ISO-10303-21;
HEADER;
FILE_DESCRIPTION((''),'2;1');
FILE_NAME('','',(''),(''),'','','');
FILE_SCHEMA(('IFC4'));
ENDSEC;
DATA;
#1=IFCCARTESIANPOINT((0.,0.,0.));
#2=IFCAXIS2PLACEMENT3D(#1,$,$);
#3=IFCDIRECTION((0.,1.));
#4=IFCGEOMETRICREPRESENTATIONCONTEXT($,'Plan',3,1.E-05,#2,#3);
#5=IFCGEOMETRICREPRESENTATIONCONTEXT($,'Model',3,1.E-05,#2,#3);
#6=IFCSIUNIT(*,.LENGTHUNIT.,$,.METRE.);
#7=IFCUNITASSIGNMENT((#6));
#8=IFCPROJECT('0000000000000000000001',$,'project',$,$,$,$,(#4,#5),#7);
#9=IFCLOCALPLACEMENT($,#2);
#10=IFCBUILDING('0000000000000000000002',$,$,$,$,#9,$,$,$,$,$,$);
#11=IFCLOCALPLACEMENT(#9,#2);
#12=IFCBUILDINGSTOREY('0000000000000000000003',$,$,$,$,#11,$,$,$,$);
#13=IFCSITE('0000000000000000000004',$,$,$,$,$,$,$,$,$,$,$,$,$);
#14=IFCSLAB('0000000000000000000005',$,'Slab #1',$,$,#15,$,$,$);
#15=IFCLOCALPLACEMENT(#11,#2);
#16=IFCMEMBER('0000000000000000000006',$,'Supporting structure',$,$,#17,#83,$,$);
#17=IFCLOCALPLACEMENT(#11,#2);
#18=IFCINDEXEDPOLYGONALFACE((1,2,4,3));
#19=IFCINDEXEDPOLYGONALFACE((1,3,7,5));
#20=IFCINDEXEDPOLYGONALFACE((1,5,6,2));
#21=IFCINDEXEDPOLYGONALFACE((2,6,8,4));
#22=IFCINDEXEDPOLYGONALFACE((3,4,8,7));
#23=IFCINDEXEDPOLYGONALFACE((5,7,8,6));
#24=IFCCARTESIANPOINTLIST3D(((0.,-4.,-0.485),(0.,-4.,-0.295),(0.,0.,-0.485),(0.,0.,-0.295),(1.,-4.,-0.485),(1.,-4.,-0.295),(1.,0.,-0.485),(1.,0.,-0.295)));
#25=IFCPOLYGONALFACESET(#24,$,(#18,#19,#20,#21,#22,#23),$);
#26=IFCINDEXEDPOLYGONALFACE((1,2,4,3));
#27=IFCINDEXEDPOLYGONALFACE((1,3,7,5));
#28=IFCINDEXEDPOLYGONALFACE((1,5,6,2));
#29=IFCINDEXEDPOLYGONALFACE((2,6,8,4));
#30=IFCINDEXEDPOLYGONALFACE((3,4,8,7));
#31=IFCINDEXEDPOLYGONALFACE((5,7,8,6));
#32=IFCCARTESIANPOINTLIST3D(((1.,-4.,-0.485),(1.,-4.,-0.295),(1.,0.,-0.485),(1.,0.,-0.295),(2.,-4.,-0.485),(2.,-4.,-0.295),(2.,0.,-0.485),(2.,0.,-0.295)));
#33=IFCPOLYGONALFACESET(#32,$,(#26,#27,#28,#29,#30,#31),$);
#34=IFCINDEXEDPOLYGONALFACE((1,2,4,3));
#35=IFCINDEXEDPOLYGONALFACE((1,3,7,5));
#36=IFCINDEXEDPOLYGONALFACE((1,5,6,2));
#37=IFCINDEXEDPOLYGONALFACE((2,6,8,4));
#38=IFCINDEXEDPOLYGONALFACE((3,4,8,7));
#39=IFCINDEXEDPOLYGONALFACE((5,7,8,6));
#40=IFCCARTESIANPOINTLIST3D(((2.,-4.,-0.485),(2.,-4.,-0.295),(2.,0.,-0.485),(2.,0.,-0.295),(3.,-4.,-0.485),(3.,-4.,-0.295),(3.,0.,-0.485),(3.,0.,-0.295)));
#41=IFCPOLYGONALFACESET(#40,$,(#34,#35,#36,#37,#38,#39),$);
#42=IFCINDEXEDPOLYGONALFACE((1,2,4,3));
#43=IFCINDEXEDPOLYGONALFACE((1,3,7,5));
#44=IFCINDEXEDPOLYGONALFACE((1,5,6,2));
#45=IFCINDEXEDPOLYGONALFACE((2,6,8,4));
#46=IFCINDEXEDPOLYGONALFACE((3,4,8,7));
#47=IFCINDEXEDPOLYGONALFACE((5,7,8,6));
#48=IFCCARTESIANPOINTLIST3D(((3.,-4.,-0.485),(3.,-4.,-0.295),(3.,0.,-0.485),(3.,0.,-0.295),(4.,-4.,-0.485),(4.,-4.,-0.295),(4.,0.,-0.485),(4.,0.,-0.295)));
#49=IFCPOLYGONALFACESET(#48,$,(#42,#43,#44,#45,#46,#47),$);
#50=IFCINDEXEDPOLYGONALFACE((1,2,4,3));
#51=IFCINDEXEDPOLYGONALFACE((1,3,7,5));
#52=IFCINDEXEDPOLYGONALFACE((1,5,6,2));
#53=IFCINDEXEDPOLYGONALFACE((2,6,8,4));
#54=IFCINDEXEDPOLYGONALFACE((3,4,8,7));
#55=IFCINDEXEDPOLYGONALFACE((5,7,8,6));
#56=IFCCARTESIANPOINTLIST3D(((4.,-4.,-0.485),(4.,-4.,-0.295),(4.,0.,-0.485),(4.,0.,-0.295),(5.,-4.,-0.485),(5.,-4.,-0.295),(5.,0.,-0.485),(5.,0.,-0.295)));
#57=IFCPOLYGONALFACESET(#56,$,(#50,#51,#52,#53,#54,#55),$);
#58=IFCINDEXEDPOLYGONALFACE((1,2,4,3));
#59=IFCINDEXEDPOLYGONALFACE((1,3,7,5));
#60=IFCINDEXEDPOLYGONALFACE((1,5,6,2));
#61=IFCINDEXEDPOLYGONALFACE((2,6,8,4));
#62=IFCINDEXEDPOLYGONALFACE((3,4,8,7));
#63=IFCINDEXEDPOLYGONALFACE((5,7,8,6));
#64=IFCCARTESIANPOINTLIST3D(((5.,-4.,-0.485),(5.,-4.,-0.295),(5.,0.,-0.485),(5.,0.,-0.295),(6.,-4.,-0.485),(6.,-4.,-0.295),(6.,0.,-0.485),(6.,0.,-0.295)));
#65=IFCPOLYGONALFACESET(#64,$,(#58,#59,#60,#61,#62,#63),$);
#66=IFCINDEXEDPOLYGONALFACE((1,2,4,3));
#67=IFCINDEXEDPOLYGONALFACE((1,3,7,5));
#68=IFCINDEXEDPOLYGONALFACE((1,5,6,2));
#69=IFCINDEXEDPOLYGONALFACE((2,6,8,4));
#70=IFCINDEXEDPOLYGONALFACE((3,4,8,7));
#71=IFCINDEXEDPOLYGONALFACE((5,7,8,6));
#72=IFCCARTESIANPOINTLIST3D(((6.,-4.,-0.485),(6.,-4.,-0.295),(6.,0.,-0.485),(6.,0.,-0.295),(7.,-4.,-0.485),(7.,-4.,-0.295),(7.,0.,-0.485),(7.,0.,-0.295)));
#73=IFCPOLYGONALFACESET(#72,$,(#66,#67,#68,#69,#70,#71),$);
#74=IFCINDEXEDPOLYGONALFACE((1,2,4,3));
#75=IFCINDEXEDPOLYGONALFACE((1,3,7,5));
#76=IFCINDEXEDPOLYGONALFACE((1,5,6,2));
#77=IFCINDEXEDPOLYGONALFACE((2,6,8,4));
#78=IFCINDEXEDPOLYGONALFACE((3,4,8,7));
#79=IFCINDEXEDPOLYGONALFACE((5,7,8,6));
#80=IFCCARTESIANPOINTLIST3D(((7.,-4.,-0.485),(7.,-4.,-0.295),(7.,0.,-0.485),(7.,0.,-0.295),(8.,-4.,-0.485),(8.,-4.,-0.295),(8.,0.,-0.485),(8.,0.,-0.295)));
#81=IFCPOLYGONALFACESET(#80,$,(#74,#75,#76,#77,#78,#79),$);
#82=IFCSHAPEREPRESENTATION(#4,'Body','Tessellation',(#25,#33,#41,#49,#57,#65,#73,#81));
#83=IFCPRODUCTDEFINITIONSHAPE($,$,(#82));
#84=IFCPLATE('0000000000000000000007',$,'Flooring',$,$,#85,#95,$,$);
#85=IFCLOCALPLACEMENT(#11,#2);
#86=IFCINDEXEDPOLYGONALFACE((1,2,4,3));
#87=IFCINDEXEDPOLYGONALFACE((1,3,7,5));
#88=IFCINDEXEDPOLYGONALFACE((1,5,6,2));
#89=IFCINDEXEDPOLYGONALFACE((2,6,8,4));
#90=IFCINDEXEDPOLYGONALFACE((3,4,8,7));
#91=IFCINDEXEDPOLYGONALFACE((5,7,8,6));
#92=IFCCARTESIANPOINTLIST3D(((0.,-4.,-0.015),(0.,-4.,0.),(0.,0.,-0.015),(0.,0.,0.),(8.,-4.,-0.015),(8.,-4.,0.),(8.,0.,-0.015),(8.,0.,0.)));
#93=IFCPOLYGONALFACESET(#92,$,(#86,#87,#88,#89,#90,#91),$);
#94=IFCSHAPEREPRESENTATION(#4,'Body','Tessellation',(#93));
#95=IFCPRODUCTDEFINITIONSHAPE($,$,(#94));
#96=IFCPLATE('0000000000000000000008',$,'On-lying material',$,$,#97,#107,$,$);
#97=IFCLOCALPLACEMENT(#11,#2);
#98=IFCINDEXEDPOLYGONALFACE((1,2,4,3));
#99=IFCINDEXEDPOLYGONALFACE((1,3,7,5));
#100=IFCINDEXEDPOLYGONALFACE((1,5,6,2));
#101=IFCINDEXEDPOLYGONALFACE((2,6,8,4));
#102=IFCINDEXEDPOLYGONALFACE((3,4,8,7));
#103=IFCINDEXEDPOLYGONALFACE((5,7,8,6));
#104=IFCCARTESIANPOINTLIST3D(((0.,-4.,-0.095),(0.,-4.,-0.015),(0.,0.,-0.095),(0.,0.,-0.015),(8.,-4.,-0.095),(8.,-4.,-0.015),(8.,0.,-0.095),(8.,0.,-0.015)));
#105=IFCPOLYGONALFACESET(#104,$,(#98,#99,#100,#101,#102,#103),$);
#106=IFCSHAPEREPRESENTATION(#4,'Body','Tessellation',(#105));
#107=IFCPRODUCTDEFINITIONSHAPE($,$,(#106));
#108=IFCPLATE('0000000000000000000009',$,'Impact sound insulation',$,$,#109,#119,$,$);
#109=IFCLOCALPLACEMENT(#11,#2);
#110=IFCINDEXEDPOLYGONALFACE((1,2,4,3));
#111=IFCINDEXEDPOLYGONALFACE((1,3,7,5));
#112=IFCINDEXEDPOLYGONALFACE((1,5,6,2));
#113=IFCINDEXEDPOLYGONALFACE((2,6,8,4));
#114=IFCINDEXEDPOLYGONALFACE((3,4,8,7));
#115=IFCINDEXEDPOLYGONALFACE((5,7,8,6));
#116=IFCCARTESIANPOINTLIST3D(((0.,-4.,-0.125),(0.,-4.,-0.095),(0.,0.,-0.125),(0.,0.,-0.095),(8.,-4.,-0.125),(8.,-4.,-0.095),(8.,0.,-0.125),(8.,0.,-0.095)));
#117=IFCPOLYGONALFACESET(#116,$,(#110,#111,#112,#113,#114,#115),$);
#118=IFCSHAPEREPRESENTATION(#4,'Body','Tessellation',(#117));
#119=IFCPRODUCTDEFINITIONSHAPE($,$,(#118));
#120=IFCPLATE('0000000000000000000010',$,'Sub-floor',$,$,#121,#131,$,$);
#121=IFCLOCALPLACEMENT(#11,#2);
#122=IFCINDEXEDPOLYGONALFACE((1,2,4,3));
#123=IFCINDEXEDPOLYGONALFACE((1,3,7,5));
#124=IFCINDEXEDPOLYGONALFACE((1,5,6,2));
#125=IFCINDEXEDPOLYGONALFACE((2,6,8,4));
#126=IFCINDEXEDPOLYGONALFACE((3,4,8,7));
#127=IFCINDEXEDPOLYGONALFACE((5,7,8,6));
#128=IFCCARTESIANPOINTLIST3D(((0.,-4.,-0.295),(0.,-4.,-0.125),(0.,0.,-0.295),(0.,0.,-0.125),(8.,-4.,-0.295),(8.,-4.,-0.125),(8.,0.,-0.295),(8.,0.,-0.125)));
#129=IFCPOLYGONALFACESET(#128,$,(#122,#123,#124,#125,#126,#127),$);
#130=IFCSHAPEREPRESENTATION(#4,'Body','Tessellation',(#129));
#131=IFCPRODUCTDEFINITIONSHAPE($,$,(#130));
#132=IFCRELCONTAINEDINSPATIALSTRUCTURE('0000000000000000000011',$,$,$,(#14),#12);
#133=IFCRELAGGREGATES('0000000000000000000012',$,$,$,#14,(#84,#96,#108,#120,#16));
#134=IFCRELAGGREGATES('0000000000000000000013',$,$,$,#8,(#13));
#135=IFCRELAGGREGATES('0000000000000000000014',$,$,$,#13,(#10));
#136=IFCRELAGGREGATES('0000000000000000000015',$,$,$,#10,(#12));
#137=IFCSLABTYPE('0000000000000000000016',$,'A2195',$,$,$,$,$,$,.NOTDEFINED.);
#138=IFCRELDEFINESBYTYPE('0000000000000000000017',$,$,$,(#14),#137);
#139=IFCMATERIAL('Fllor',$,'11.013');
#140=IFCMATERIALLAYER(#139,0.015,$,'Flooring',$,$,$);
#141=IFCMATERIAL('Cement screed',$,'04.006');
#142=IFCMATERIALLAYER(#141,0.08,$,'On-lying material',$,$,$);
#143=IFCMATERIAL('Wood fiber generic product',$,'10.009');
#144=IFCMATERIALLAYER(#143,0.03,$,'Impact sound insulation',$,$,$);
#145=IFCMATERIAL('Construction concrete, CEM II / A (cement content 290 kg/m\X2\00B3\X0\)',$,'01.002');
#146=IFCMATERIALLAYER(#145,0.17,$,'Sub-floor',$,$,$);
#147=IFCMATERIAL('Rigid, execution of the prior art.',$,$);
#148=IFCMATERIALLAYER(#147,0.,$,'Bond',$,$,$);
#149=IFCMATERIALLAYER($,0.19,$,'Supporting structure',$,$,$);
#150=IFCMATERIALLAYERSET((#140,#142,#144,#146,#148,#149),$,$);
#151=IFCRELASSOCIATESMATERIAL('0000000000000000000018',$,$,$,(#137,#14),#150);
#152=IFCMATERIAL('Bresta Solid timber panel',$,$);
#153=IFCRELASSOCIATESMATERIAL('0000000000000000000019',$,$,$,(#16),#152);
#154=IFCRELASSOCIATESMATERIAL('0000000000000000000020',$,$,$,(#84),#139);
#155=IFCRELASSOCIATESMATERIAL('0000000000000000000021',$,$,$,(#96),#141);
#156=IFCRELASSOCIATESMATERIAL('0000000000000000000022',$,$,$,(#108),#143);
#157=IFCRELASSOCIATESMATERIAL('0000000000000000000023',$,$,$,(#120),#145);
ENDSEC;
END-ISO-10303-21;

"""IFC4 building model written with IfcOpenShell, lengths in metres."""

from ifc_helpers import new_model, si_unit, direction, frame, frame_2d, origin, origin_with_axes, place, context, project, spatial, rectangle, extrude, material, layer, layer_set, type_object, element, aggregate, save


model = new_model("IFC4")

# Units and contexts
plan_context = context("Plan", 3, precision=1e-05, world=origin(), true_north=direction((0.0, 1.0)))
model_context = context("Model", 3, precision=1e-05, world=origin(), true_north=direction((0.0, 1.0)))
ifc_project = project(units=[si_unit("LENGTHUNIT", "METRE")], contexts=[plan_context, model_context])

# Site, building, storey
site = spatial("IfcSite", under=ifc_project)
building_placement = place(None, origin())
building = spatial("IfcBuilding", under=site, at=building_placement)
storey_placement = place(building_placement, origin())
storey = spatial("IfcBuildingStorey", under=building, at=storey_placement)

# Slab, member, plates
ifc_material_1 = material(Name="Fllor", Category="11.013")
ifc_layer_1 = layer(ifc_material_1, 0.015, Name="Flooring")
ifc_material_2 = material(Name="Cement screed", Category="04.006")
ifc_layer_2 = layer(ifc_material_2, 0.08, Name="On-lying material")
ifc_material_3 = material(Name="Wood fiber generic product", Category="10.009")
ifc_layer_3 = layer(ifc_material_3, 0.03, Name="Impact sound insulation")
ifc_material_4 = material(Name="Construction concrete, CEM II / A (cement content 290 kg/m³)", Category="01.002")
ifc_layer_4 = layer(ifc_material_4, 0.17, Name="Sub-floor")
ifc_material_5 = material(Name="Rigid, execution of the prior art.")
ifc_layer_5 = layer(ifc_material_5, 0.0, Name="Bond")
ifc_layer_6 = layer(None, 0.19, Name="Supporting structure")
ifc_layer_set = layer_set([ifc_layer_1, ifc_layer_2, ifc_layer_3, ifc_layer_4, ifc_layer_5, ifc_layer_6])
slab_type = type_object("IfcSlabType", Name="A2195", PredefinedType="NOTDEFINED", material=ifc_layer_set)
slab_placement = place(None, frame((0.0, 0.0, 0.0), z_axis=(0.0, 0.0, -1.0), x_axis=(1.0, 0.0, 0.0)))
slab = element("IfcSlab", 1, at=slab_placement, inside=storey, type_object=slab_type, material=ifc_layer_set, Name="Slab #1")
ifc_material_6 = material(Name="Bresta Solid timber panel")
member_placement = place(slab_placement, origin())
member = element("IfcMember", 2, at=member_placement, material=ifc_material_6, Name="Supporting structure", context=plan_context, shape_type="SweptSolid", body=[
    extrude(rectangle(XDim=1.0, YDim=0.19, at=frame_2d((0.5, 0.095), x_axis=(1.0, 0.0))), frame((0.0, 4.0, 0.295), z_axis=(0.0, -1.0, 0.0), x_axis=(1.0, 0.0, 0.0)), (0.0, 0.0, 1.0), 4.0),
    extrude(rectangle(XDim=1.0, YDim=0.19, at=frame_2d((0.5, 0.095), x_axis=(1.0, 0.0))), frame((1.0, 4.0, 0.295), z_axis=(0.0, -1.0, 0.0), x_axis=(1.0, 0.0, 0.0)), (0.0, 0.0, 1.0), 4.0),
    extrude(rectangle(XDim=1.0, YDim=0.19, at=frame_2d((0.5, 0.095), x_axis=(1.0, 0.0))), frame((2.0, 4.0, 0.295), z_axis=(0.0, -1.0, 0.0), x_axis=(1.0, 0.0, 0.0)), (0.0, 0.0, 1.0), 4.0),
    extrude(rectangle(XDim=1.0, YDim=0.19, at=frame_2d((0.5, 0.095), x_axis=(1.0, 0.0))), frame((3.0, 4.0, 0.295), z_axis=(0.0, -1.0, 0.0), x_axis=(1.0, 0.0, 0.0)), (0.0, 0.0, 1.0), 4.0),
    extrude(rectangle(XDim=1.0, YDim=0.19, at=frame_2d((0.5, 0.095), x_axis=(1.0, 0.0))), frame((4.0, 4.0, 0.295), z_axis=(0.0, -1.0, 0.0), x_axis=(1.0, 0.0, 0.0)), (0.0, 0.0, 1.0), 4.0),
    extrude(rectangle(XDim=1.0, YDim=0.19, at=frame_2d((0.5, 0.095), x_axis=(1.0, 0.0))), frame((5.0, 4.0, 0.295), z_axis=(0.0, -1.0, 0.0), x_axis=(1.0, 0.0, 0.0)), (0.0, 0.0, 1.0), 4.0),
    extrude(rectangle(XDim=1.0, YDim=0.19, at=frame_2d((0.5, 0.095), x_axis=(1.0, 0.0))), frame((6.0, 4.0, 0.295), z_axis=(0.0, -1.0, 0.0), x_axis=(1.0, 0.0, 0.0)), (0.0, 0.0, 1.0), 4.0),
    extrude(rectangle(XDim=1.0, YDim=0.19, at=frame_2d((0.5, 0.095), x_axis=(1.0, 0.0))), frame((7.0, 4.0, 0.295), z_axis=(0.0, -1.0, 0.0), x_axis=(1.0, 0.0, 0.0)), (0.0, 0.0, 1.0), 4.0),
])
plate_1_placement = place(slab_placement, origin())
plate_1 = element("IfcPlate", 3, at=plate_1_placement, material=ifc_material_1, Name="Flooring", context=plan_context, shape_type="SweptSolid", body=[
    extrude(rectangle(XDim=8.0, YDim=4.0, at=frame_2d((4.0, 2.0), x_axis=(1.0, 0.0))), origin_with_axes(), (0.0, 0.0, 1.0), 0.015),
])
plate_2_placement = place(slab_placement, origin())
plate_2 = element("IfcPlate", 4, at=plate_2_placement, material=ifc_material_2, Name="On-lying material", context=plan_context, shape_type="SweptSolid", body=[
    extrude(rectangle(XDim=8.0, YDim=4.0, at=frame_2d((4.0, 2.0), x_axis=(1.0, 0.0))), frame((0.0, 0.0, 0.015), z_axis=(0.0, 0.0, 1.0), x_axis=(1.0, 0.0, 0.0)), (0.0, 0.0, 1.0), 0.08),
])
plate_3_placement = place(slab_placement, origin())
plate_3 = element("IfcPlate", 5, at=plate_3_placement, material=ifc_material_3, Name="Impact sound insulation", context=plan_context, shape_type="SweptSolid", body=[
    extrude(rectangle(XDim=8.0, YDim=4.0, at=frame_2d((4.0, 2.0), x_axis=(1.0, 0.0))), frame((0.0, 0.0, 0.095), z_axis=(0.0, 0.0, 1.0), x_axis=(1.0, 0.0, 0.0)), (0.0, 0.0, 1.0), 0.03),
])
plate_4_placement = place(slab_placement, origin())
plate_4 = element("IfcPlate", 6, at=plate_4_placement, material=ifc_material_4, Name="Sub-floor", context=plan_context, shape_type="SweptSolid", body=[
    extrude(rectangle(XDim=8.0, YDim=4.0, at=frame_2d((4.0, 2.0), x_axis=(1.0, 0.0))), frame((0.0, 0.0, 0.125), z_axis=(0.0, 0.0, 1.0), x_axis=(1.0, 0.0, 0.0)), (0.0, 0.0, 1.0), 0.17),
])
aggregate(slab, [plate_1, plate_2, plate_3, plate_4, member])

save(model, "model.ifc")
